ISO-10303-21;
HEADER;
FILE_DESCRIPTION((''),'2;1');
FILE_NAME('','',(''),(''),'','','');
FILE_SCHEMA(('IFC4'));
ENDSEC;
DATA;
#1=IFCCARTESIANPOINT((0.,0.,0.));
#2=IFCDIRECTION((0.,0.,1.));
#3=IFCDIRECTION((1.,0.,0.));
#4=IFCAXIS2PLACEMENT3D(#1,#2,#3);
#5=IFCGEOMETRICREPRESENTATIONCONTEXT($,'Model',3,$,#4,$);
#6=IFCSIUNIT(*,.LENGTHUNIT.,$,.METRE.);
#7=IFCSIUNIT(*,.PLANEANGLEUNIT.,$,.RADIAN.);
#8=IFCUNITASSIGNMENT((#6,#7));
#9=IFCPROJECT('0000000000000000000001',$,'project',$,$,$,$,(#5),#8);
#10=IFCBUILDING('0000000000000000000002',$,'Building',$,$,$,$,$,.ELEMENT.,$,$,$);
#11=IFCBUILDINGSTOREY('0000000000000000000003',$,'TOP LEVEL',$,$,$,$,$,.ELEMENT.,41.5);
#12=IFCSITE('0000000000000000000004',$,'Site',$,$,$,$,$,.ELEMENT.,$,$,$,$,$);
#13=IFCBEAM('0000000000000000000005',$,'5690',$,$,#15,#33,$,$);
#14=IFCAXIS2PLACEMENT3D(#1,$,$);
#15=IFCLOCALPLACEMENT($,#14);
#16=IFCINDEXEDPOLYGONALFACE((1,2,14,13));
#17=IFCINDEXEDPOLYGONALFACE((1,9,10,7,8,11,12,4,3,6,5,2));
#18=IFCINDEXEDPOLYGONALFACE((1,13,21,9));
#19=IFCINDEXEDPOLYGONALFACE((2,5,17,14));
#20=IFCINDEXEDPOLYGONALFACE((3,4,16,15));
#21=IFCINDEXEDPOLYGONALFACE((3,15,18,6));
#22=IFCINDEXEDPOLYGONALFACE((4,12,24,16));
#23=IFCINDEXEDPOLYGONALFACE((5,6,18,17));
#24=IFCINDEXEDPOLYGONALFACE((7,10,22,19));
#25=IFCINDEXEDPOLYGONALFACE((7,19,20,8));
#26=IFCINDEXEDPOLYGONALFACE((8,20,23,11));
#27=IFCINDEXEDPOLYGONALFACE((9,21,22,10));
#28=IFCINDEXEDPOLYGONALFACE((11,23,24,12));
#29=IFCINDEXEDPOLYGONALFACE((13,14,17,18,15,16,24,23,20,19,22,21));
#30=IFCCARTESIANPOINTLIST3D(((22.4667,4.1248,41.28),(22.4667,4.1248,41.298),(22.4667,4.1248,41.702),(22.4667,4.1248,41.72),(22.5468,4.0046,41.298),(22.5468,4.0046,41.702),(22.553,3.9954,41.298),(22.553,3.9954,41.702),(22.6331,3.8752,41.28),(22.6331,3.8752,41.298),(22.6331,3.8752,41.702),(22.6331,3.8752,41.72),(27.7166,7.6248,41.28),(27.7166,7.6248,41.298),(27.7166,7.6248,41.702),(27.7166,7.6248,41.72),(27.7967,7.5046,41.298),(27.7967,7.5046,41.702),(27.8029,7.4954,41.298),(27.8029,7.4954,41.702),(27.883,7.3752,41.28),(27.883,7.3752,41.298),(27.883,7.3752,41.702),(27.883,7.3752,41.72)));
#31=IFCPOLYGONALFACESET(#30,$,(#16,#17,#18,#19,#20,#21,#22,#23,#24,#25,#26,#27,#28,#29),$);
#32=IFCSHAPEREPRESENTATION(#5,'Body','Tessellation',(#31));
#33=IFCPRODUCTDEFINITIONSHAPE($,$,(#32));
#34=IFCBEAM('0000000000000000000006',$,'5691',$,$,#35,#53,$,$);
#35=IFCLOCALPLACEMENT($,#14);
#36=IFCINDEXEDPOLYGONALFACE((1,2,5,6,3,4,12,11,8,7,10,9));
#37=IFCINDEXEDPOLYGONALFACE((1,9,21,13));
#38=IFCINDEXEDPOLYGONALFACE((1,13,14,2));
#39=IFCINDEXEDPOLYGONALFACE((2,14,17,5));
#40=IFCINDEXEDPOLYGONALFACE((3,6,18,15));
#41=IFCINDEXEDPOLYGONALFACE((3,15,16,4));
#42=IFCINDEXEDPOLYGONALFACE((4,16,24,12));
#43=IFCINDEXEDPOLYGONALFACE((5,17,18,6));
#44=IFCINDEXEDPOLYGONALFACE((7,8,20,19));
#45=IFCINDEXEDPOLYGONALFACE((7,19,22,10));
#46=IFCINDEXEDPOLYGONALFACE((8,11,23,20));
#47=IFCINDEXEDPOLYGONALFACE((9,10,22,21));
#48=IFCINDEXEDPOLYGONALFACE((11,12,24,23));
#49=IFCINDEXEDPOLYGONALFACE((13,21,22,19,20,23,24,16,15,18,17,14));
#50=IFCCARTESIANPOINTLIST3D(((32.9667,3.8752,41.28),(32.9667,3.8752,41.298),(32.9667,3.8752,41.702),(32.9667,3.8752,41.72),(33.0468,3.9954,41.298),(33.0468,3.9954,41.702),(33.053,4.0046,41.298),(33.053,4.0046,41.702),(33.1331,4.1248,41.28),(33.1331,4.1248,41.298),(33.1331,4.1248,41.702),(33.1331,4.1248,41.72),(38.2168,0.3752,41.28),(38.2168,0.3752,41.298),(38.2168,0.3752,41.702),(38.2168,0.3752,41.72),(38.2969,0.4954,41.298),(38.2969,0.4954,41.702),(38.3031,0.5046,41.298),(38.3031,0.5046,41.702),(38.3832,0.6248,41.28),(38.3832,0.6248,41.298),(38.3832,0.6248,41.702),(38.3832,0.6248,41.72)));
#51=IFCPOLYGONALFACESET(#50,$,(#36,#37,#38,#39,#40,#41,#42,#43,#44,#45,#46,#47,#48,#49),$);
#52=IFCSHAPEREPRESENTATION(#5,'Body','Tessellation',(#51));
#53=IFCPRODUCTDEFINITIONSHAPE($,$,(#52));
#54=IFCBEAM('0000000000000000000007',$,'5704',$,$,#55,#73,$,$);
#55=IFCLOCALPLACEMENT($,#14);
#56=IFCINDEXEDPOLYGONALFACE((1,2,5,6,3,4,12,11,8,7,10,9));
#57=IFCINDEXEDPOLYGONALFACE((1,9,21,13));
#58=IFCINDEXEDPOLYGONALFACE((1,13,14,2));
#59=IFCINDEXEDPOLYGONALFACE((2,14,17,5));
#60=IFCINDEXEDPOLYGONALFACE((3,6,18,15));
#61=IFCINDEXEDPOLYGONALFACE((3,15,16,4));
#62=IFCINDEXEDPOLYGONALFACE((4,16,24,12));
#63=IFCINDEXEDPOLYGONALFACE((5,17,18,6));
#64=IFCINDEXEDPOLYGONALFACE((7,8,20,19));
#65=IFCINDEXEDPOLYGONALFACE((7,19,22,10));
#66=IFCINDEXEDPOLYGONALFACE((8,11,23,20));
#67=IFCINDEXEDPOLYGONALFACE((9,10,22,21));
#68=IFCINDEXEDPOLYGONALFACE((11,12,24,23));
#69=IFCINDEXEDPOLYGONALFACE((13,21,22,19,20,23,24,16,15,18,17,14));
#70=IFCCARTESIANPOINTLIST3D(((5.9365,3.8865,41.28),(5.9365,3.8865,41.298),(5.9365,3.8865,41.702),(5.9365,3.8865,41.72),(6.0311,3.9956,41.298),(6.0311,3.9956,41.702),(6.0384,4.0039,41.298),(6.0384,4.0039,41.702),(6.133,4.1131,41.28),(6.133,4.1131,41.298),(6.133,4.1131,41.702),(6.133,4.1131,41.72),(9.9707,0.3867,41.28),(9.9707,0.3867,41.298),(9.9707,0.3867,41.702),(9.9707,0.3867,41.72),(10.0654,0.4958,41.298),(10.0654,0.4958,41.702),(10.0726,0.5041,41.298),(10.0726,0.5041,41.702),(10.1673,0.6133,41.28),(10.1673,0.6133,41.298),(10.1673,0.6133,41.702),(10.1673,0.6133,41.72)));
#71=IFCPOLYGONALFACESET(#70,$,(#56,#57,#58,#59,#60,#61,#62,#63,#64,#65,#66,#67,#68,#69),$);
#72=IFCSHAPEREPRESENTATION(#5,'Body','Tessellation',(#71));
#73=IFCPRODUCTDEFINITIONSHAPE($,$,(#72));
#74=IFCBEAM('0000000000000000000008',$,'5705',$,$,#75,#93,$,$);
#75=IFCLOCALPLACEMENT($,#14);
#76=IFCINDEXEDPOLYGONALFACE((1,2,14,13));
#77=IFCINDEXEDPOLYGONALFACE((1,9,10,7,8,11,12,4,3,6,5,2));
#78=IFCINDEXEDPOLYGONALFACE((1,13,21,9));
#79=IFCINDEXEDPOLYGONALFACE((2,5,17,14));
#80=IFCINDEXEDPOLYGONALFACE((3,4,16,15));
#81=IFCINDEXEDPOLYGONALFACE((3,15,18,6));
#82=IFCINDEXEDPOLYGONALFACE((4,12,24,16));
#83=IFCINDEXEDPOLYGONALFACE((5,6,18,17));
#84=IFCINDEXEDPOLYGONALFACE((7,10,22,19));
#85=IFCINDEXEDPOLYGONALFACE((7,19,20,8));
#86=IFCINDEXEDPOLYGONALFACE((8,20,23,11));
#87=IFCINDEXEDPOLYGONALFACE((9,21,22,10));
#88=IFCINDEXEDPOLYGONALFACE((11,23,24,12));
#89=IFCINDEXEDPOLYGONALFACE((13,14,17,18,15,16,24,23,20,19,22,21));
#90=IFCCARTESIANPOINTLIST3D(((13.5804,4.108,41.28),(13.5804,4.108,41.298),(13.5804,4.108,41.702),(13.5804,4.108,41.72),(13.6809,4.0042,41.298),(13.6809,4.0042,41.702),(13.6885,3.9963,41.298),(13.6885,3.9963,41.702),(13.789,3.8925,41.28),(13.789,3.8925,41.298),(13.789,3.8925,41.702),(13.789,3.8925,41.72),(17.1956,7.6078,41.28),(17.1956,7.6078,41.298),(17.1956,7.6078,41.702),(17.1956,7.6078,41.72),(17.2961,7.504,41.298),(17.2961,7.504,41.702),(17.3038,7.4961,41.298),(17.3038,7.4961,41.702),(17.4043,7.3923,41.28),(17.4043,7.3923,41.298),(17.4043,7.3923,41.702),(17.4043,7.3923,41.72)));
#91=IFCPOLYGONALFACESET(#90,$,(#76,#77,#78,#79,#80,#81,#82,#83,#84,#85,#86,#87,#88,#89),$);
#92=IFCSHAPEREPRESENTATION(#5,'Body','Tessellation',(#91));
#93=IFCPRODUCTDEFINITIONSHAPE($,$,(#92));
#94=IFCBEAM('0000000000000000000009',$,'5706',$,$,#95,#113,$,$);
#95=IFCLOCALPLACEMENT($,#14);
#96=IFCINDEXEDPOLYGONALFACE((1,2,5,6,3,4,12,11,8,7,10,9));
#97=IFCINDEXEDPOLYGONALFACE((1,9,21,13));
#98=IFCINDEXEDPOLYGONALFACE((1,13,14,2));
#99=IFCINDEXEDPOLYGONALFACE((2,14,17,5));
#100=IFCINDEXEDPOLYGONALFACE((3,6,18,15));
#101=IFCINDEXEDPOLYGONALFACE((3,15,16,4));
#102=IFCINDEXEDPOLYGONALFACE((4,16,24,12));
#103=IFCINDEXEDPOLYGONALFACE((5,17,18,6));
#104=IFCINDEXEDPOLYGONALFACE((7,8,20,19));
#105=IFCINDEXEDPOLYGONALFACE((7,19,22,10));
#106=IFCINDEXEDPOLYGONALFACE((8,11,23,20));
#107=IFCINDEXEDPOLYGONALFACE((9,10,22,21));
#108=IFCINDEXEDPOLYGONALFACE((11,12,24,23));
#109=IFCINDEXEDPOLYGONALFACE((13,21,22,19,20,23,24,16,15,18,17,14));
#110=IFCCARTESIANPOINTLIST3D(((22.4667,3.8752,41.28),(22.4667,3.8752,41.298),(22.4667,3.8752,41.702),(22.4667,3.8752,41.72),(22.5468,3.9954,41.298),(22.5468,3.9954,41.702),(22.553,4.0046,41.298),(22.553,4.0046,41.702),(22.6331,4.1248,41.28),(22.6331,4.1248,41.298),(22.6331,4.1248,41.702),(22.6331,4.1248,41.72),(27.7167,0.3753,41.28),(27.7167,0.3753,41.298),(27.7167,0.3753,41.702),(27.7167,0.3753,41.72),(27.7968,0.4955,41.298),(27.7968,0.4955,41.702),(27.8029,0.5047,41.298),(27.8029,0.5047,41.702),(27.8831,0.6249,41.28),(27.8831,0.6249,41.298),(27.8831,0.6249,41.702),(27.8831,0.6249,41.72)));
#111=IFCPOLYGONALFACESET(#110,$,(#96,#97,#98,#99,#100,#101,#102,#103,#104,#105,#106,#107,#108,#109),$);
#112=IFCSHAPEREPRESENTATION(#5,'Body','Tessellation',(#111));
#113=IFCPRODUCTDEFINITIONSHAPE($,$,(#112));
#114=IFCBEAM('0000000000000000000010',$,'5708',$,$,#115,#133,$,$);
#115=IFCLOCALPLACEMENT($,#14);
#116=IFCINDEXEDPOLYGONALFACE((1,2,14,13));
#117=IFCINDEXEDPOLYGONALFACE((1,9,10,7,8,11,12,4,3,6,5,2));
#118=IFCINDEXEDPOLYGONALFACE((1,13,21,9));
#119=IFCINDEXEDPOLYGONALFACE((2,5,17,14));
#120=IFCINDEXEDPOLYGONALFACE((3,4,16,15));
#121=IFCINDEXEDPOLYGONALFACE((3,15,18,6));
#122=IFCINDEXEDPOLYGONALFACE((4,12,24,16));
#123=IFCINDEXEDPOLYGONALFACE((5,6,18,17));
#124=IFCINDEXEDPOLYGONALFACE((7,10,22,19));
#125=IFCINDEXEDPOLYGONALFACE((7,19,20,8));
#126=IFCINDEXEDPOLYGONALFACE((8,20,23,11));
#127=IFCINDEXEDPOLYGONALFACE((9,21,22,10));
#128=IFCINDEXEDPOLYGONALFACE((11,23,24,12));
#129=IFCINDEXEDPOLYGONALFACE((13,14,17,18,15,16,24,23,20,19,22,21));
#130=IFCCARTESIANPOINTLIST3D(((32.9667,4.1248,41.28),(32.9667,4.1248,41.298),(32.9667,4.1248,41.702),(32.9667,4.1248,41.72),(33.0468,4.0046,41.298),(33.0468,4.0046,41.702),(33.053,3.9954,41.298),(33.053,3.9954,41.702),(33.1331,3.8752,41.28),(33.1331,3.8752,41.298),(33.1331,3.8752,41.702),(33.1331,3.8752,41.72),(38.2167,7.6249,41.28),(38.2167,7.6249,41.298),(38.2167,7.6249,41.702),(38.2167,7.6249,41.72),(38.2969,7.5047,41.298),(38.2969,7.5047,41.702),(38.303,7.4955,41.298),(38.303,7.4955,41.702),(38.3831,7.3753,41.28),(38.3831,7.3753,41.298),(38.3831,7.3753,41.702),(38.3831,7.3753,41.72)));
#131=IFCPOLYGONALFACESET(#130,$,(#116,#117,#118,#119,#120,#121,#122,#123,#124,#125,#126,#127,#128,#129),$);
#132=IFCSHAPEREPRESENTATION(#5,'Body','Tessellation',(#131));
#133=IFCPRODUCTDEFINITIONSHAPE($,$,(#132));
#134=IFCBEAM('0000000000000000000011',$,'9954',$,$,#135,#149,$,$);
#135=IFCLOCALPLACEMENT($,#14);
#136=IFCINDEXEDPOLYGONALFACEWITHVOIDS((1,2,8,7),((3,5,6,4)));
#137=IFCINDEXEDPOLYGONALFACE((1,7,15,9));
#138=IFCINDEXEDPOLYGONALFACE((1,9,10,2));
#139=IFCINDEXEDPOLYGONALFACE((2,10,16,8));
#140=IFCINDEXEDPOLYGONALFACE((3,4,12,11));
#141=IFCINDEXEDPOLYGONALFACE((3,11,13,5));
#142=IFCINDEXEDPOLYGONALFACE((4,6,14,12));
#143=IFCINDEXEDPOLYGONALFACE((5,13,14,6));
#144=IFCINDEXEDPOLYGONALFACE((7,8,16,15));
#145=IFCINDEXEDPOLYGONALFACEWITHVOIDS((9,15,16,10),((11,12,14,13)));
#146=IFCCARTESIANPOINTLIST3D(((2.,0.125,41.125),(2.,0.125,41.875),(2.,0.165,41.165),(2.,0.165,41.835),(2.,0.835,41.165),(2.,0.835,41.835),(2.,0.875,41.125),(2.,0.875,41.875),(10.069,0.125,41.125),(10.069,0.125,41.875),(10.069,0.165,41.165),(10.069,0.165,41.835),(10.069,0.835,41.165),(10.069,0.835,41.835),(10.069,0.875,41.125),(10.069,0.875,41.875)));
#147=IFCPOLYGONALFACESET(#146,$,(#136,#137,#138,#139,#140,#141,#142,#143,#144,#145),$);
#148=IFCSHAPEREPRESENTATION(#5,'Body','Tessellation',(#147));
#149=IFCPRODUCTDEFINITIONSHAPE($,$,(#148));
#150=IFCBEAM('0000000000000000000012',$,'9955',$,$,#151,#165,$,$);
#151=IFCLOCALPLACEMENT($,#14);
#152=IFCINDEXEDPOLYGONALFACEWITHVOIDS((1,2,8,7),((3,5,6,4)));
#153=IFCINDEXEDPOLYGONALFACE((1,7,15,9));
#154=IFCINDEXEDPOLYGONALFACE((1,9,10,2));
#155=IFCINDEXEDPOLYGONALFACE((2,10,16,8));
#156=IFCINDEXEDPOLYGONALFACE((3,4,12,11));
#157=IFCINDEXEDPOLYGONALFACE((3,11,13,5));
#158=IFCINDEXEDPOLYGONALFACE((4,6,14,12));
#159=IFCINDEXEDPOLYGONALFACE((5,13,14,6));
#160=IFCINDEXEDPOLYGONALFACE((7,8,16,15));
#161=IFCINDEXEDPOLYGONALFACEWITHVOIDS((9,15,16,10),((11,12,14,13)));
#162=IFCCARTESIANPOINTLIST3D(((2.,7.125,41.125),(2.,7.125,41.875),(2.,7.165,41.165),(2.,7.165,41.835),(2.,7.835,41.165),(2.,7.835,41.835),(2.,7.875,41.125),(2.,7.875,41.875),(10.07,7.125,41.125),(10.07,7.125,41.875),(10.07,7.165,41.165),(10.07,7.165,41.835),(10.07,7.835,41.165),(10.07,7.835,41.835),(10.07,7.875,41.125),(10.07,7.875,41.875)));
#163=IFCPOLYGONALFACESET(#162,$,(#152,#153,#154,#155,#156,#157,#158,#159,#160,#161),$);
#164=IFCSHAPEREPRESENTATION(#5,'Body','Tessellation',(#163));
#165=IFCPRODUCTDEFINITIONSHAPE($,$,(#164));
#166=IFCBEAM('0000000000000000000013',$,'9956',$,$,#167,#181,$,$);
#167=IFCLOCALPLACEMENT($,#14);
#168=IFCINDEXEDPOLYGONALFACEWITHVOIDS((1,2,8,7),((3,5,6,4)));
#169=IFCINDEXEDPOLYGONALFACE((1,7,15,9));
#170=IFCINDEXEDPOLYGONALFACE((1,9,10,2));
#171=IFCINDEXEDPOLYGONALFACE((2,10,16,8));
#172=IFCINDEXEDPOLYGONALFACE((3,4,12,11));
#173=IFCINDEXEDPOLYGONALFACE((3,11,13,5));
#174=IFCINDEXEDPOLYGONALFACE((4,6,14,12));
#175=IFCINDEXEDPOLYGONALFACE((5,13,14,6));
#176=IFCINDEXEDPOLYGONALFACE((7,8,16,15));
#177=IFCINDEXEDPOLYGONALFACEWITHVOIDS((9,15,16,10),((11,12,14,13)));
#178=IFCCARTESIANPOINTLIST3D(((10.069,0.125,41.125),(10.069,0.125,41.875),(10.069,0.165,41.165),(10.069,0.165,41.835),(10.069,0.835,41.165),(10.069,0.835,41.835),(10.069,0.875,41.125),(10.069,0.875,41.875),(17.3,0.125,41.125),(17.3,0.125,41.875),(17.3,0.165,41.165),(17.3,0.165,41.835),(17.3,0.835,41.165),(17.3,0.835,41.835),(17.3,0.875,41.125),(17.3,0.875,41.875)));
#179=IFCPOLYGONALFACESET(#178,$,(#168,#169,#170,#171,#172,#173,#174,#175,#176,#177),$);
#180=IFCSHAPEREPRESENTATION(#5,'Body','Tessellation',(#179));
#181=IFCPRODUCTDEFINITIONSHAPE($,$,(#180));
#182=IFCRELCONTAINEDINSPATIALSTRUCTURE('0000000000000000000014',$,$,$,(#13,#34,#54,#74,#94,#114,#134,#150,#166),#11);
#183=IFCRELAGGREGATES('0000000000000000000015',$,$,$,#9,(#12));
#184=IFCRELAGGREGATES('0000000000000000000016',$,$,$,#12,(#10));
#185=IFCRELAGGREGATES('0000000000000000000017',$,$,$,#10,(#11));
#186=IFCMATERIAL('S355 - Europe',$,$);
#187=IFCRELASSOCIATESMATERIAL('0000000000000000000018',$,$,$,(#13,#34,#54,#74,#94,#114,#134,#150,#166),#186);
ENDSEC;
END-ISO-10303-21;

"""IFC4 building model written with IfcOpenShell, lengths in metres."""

from ifc_helpers import new_model, si_unit, frame, origin_with_axes, origin_2d_with_axis, place, context, project, spatial, hollow_rectangle, i_section, extrude, material, material_profile, profile_set, profile_usage, element, save


model = new_model("IFC4")

# Units and contexts
model_context = context("Model", 3, world=origin_with_axes())
ifc_project = project(units=[si_unit("LENGTHUNIT", "METRE"), si_unit("PLANEANGLEUNIT", "RADIAN")], contexts=[model_context])

# Site, building, storey
site = spatial("IfcSite", under=ifc_project, Name="Site", CompositionType="ELEMENT")
building = spatial("IfcBuilding", under=site, Name="Building", CompositionType="ELEMENT")
storey = spatial("IfcBuildingStorey", under=building, Name="TOP LEVEL", CompositionType="ELEMENT", Elevation=41.5)

# Beams
ifc_material = material(Name="S355 - Europe")
ifc_material_profile_1 = material_profile(ifc_material, i_section(OverallWidth=0.3, OverallDepth=0.44, WebThickness=0.011, FlangeThickness=0.018, at=origin_2d_with_axis()))
ifc_profile_set_1 = profile_set([ifc_material_profile_1])
ifc_profile_usage_1 = profile_usage(ifc_profile_set_1, cardinal=10)
beam_1_placement = place(None, frame((22.5499, 4.0, 41.5), z_axis=(0.832045, 0.554708, 0.0), x_axis=(-0.554708, 0.832045, 0.0)))
element("IfcBeam", 1, at=beam_1_placement, inside=storey, material=ifc_profile_usage_1, Name="5690", context=model_context, shape_type="SweptSolid", body=[
    extrude(i_section(OverallWidth=0.3, OverallDepth=0.44, WebThickness=0.011, FlangeThickness=0.018, at=origin_2d_with_axis()), origin_with_axes(), (0.0, 0.0, 1.0), 6.3096),
])
ifc_material_profile_2 = material_profile(ifc_material, i_section(OverallWidth=0.3, OverallDepth=0.44, WebThickness=0.011, FlangeThickness=0.018, at=origin_2d_with_axis()))
ifc_profile_set_2 = profile_set([ifc_material_profile_2])
ifc_profile_usage_2 = profile_usage(ifc_profile_set_2, cardinal=10)
beam_2_placement = place(None, frame((33.0499, 4.0, 41.5), z_axis=(0.832055, -0.554693, 0.0), x_axis=(0.554693, 0.832055, 0.0)))
element("IfcBeam", 2, at=beam_2_placement, inside=storey, material=ifc_profile_usage_2, Name="5691", context=model_context, shape_type="SweptSolid", body=[
    extrude(i_section(OverallWidth=0.3, OverallDepth=0.44, WebThickness=0.011, FlangeThickness=0.018, at=origin_2d_with_axis()), origin_with_axes(), (0.0, 0.0, 1.0), 6.3098),
])
ifc_material_profile_3 = material_profile(ifc_material, i_section(OverallWidth=0.3, OverallDepth=0.44, WebThickness=0.011, FlangeThickness=0.018, at=origin_2d_with_axis()))
ifc_profile_set_3 = profile_set([ifc_material_profile_3])
ifc_profile_usage_3 = profile_usage(ifc_profile_set_3, cardinal=10)
beam_3_placement = place(None, frame((6.0347, 3.9998, 41.5), z_axis=(0.75537, -0.655299, 0.0), x_axis=(0.655299, 0.75537, 0.0)))
element("IfcBeam", 3, at=beam_3_placement, inside=storey, material=ifc_profile_usage_3, Name="5704", context=model_context, shape_type="SweptSolid", body=[
    extrude(i_section(OverallWidth=0.3, OverallDepth=0.44, WebThickness=0.011, FlangeThickness=0.018, at=origin_2d_with_axis()), origin_with_axes(), (0.0, 0.0, 1.0), 5.3407),
])
ifc_material_profile_4 = material_profile(ifc_material, i_section(OverallWidth=0.3, OverallDepth=0.44, WebThickness=0.011, FlangeThickness=0.018, at=origin_2d_with_axis()))
ifc_profile_set_4 = profile_set([ifc_material_profile_4])
ifc_profile_usage_4 = profile_usage(ifc_profile_set_4, cardinal=10)
beam_4_placement = place(None, frame((13.6847, 4.0003, 41.5), z_axis=(0.718483, 0.695544, 0.0), x_axis=(-0.695544, 0.718483, 0.0)))
element("IfcBeam", 4, at=beam_4_placement, inside=storey, material=ifc_profile_usage_4, Name="5705", context=model_context, shape_type="SweptSolid", body=[
    extrude(i_section(OverallWidth=0.3, OverallDepth=0.44, WebThickness=0.011, FlangeThickness=0.018, at=origin_2d_with_axis()), origin_with_axes(), (0.0, 0.0, 1.0), 5.0318),
])
ifc_material_profile_5 = material_profile(ifc_material, i_section(OverallWidth=0.3, OverallDepth=0.44, WebThickness=0.011, FlangeThickness=0.018, at=origin_2d_with_axis()))
ifc_profile_set_5 = profile_set([ifc_material_profile_5])
ifc_profile_usage_5 = profile_usage(ifc_profile_set_5, cardinal=10)
beam_5_placement = place(None, frame((22.5499, 4.0, 41.5), z_axis=(0.832055, -0.554693, 0.0), x_axis=(0.554693, 0.832055, 0.0)))
element("IfcBeam", 5, at=beam_5_placement, inside=storey, material=ifc_profile_usage_5, Name="5706", context=model_context, shape_type="SweptSolid", body=[
    extrude(i_section(OverallWidth=0.3, OverallDepth=0.44, WebThickness=0.011, FlangeThickness=0.018, at=origin_2d_with_axis()), origin_with_axes(), (0.0, 0.0, 1.0), 6.3096),
])
ifc_material_profile_6 = material_profile(ifc_material, i_section(OverallWidth=0.3, OverallDepth=0.44, WebThickness=0.011, FlangeThickness=0.018, at=origin_2d_with_axis()))
ifc_profile_set_6 = profile_set([ifc_material_profile_6])
ifc_profile_usage_6 = profile_usage(ifc_profile_set_6, cardinal=10)
beam_6_placement = place(None, frame((33.0499, 4.0, 41.5), z_axis=(0.832045, 0.554708, 0.0), x_axis=(-0.554708, 0.832045, 0.0)))
element("IfcBeam", 6, at=beam_6_placement, inside=storey, material=ifc_profile_usage_6, Name="5708", context=model_context, shape_type="SweptSolid", body=[
    extrude(i_section(OverallWidth=0.3, OverallDepth=0.44, WebThickness=0.011, FlangeThickness=0.018, at=origin_2d_with_axis()), origin_with_axes(), (0.0, 0.0, 1.0), 6.3098),
])
ifc_material_profile_7 = material_profile(ifc_material, hollow_rectangle(XDim=0.75, YDim=0.75, WallThickness=0.04, at=origin_2d_with_axis()))
ifc_profile_set_7 = profile_set([ifc_material_profile_7])
ifc_profile_usage_7 = profile_usage(ifc_profile_set_7, cardinal=10)
beam_7_placement = place(None, frame((10.069, 0.5, 41.5), z_axis=(-1.0, 0.0, 0.0), x_axis=(0.0, -1.0, 0.0)))
element("IfcBeam", 7, at=beam_7_placement, inside=storey, material=ifc_profile_usage_7, Name="9954", context=model_context, shape_type="SweptSolid", body=[
    extrude(hollow_rectangle(XDim=0.75, YDim=0.75, WallThickness=0.04, at=origin_2d_with_axis()), origin_with_axes(), (0.0, 0.0, 1.0), 8.069),
])
ifc_material_profile_8 = material_profile(ifc_material, hollow_rectangle(XDim=0.75, YDim=0.75, WallThickness=0.04, at=origin_2d_with_axis()))
ifc_profile_set_8 = profile_set([ifc_material_profile_8])
ifc_profile_usage_8 = profile_usage(ifc_profile_set_8, cardinal=10)
beam_8_placement = place(None, frame((10.07, 7.5, 41.5), z_axis=(-1.0, 0.0, 0.0), x_axis=(0.0, -1.0, 0.0)))
element("IfcBeam", 8, at=beam_8_placement, inside=storey, material=ifc_profile_usage_8, Name="9955", context=model_context, shape_type="SweptSolid", body=[
    extrude(hollow_rectangle(XDim=0.75, YDim=0.75, WallThickness=0.04, at=origin_2d_with_axis()), origin_with_axes(), (0.0, 0.0, 1.0), 8.07),
])
ifc_material_profile_9 = material_profile(ifc_material, hollow_rectangle(XDim=0.75, YDim=0.75, WallThickness=0.04, at=origin_2d_with_axis()))
ifc_profile_set_9 = profile_set([ifc_material_profile_9])
ifc_profile_usage_9 = profile_usage(ifc_profile_set_9, cardinal=10)
beam_9_placement = place(None, frame((17.3, 0.5, 41.5), z_axis=(-1.0, 0.0, 0.0), x_axis=(0.0, -1.0, 0.0)))
element("IfcBeam", 9, at=beam_9_placement, inside=storey, material=ifc_profile_usage_9, Name="9956", context=model_context, shape_type="SweptSolid", body=[
    extrude(hollow_rectangle(XDim=0.75, YDim=0.75, WallThickness=0.04, at=origin_2d_with_axis()), origin_with_axes(), (0.0, 0.0, 1.0), 7.231),
])

save(model, "model.ifc")
